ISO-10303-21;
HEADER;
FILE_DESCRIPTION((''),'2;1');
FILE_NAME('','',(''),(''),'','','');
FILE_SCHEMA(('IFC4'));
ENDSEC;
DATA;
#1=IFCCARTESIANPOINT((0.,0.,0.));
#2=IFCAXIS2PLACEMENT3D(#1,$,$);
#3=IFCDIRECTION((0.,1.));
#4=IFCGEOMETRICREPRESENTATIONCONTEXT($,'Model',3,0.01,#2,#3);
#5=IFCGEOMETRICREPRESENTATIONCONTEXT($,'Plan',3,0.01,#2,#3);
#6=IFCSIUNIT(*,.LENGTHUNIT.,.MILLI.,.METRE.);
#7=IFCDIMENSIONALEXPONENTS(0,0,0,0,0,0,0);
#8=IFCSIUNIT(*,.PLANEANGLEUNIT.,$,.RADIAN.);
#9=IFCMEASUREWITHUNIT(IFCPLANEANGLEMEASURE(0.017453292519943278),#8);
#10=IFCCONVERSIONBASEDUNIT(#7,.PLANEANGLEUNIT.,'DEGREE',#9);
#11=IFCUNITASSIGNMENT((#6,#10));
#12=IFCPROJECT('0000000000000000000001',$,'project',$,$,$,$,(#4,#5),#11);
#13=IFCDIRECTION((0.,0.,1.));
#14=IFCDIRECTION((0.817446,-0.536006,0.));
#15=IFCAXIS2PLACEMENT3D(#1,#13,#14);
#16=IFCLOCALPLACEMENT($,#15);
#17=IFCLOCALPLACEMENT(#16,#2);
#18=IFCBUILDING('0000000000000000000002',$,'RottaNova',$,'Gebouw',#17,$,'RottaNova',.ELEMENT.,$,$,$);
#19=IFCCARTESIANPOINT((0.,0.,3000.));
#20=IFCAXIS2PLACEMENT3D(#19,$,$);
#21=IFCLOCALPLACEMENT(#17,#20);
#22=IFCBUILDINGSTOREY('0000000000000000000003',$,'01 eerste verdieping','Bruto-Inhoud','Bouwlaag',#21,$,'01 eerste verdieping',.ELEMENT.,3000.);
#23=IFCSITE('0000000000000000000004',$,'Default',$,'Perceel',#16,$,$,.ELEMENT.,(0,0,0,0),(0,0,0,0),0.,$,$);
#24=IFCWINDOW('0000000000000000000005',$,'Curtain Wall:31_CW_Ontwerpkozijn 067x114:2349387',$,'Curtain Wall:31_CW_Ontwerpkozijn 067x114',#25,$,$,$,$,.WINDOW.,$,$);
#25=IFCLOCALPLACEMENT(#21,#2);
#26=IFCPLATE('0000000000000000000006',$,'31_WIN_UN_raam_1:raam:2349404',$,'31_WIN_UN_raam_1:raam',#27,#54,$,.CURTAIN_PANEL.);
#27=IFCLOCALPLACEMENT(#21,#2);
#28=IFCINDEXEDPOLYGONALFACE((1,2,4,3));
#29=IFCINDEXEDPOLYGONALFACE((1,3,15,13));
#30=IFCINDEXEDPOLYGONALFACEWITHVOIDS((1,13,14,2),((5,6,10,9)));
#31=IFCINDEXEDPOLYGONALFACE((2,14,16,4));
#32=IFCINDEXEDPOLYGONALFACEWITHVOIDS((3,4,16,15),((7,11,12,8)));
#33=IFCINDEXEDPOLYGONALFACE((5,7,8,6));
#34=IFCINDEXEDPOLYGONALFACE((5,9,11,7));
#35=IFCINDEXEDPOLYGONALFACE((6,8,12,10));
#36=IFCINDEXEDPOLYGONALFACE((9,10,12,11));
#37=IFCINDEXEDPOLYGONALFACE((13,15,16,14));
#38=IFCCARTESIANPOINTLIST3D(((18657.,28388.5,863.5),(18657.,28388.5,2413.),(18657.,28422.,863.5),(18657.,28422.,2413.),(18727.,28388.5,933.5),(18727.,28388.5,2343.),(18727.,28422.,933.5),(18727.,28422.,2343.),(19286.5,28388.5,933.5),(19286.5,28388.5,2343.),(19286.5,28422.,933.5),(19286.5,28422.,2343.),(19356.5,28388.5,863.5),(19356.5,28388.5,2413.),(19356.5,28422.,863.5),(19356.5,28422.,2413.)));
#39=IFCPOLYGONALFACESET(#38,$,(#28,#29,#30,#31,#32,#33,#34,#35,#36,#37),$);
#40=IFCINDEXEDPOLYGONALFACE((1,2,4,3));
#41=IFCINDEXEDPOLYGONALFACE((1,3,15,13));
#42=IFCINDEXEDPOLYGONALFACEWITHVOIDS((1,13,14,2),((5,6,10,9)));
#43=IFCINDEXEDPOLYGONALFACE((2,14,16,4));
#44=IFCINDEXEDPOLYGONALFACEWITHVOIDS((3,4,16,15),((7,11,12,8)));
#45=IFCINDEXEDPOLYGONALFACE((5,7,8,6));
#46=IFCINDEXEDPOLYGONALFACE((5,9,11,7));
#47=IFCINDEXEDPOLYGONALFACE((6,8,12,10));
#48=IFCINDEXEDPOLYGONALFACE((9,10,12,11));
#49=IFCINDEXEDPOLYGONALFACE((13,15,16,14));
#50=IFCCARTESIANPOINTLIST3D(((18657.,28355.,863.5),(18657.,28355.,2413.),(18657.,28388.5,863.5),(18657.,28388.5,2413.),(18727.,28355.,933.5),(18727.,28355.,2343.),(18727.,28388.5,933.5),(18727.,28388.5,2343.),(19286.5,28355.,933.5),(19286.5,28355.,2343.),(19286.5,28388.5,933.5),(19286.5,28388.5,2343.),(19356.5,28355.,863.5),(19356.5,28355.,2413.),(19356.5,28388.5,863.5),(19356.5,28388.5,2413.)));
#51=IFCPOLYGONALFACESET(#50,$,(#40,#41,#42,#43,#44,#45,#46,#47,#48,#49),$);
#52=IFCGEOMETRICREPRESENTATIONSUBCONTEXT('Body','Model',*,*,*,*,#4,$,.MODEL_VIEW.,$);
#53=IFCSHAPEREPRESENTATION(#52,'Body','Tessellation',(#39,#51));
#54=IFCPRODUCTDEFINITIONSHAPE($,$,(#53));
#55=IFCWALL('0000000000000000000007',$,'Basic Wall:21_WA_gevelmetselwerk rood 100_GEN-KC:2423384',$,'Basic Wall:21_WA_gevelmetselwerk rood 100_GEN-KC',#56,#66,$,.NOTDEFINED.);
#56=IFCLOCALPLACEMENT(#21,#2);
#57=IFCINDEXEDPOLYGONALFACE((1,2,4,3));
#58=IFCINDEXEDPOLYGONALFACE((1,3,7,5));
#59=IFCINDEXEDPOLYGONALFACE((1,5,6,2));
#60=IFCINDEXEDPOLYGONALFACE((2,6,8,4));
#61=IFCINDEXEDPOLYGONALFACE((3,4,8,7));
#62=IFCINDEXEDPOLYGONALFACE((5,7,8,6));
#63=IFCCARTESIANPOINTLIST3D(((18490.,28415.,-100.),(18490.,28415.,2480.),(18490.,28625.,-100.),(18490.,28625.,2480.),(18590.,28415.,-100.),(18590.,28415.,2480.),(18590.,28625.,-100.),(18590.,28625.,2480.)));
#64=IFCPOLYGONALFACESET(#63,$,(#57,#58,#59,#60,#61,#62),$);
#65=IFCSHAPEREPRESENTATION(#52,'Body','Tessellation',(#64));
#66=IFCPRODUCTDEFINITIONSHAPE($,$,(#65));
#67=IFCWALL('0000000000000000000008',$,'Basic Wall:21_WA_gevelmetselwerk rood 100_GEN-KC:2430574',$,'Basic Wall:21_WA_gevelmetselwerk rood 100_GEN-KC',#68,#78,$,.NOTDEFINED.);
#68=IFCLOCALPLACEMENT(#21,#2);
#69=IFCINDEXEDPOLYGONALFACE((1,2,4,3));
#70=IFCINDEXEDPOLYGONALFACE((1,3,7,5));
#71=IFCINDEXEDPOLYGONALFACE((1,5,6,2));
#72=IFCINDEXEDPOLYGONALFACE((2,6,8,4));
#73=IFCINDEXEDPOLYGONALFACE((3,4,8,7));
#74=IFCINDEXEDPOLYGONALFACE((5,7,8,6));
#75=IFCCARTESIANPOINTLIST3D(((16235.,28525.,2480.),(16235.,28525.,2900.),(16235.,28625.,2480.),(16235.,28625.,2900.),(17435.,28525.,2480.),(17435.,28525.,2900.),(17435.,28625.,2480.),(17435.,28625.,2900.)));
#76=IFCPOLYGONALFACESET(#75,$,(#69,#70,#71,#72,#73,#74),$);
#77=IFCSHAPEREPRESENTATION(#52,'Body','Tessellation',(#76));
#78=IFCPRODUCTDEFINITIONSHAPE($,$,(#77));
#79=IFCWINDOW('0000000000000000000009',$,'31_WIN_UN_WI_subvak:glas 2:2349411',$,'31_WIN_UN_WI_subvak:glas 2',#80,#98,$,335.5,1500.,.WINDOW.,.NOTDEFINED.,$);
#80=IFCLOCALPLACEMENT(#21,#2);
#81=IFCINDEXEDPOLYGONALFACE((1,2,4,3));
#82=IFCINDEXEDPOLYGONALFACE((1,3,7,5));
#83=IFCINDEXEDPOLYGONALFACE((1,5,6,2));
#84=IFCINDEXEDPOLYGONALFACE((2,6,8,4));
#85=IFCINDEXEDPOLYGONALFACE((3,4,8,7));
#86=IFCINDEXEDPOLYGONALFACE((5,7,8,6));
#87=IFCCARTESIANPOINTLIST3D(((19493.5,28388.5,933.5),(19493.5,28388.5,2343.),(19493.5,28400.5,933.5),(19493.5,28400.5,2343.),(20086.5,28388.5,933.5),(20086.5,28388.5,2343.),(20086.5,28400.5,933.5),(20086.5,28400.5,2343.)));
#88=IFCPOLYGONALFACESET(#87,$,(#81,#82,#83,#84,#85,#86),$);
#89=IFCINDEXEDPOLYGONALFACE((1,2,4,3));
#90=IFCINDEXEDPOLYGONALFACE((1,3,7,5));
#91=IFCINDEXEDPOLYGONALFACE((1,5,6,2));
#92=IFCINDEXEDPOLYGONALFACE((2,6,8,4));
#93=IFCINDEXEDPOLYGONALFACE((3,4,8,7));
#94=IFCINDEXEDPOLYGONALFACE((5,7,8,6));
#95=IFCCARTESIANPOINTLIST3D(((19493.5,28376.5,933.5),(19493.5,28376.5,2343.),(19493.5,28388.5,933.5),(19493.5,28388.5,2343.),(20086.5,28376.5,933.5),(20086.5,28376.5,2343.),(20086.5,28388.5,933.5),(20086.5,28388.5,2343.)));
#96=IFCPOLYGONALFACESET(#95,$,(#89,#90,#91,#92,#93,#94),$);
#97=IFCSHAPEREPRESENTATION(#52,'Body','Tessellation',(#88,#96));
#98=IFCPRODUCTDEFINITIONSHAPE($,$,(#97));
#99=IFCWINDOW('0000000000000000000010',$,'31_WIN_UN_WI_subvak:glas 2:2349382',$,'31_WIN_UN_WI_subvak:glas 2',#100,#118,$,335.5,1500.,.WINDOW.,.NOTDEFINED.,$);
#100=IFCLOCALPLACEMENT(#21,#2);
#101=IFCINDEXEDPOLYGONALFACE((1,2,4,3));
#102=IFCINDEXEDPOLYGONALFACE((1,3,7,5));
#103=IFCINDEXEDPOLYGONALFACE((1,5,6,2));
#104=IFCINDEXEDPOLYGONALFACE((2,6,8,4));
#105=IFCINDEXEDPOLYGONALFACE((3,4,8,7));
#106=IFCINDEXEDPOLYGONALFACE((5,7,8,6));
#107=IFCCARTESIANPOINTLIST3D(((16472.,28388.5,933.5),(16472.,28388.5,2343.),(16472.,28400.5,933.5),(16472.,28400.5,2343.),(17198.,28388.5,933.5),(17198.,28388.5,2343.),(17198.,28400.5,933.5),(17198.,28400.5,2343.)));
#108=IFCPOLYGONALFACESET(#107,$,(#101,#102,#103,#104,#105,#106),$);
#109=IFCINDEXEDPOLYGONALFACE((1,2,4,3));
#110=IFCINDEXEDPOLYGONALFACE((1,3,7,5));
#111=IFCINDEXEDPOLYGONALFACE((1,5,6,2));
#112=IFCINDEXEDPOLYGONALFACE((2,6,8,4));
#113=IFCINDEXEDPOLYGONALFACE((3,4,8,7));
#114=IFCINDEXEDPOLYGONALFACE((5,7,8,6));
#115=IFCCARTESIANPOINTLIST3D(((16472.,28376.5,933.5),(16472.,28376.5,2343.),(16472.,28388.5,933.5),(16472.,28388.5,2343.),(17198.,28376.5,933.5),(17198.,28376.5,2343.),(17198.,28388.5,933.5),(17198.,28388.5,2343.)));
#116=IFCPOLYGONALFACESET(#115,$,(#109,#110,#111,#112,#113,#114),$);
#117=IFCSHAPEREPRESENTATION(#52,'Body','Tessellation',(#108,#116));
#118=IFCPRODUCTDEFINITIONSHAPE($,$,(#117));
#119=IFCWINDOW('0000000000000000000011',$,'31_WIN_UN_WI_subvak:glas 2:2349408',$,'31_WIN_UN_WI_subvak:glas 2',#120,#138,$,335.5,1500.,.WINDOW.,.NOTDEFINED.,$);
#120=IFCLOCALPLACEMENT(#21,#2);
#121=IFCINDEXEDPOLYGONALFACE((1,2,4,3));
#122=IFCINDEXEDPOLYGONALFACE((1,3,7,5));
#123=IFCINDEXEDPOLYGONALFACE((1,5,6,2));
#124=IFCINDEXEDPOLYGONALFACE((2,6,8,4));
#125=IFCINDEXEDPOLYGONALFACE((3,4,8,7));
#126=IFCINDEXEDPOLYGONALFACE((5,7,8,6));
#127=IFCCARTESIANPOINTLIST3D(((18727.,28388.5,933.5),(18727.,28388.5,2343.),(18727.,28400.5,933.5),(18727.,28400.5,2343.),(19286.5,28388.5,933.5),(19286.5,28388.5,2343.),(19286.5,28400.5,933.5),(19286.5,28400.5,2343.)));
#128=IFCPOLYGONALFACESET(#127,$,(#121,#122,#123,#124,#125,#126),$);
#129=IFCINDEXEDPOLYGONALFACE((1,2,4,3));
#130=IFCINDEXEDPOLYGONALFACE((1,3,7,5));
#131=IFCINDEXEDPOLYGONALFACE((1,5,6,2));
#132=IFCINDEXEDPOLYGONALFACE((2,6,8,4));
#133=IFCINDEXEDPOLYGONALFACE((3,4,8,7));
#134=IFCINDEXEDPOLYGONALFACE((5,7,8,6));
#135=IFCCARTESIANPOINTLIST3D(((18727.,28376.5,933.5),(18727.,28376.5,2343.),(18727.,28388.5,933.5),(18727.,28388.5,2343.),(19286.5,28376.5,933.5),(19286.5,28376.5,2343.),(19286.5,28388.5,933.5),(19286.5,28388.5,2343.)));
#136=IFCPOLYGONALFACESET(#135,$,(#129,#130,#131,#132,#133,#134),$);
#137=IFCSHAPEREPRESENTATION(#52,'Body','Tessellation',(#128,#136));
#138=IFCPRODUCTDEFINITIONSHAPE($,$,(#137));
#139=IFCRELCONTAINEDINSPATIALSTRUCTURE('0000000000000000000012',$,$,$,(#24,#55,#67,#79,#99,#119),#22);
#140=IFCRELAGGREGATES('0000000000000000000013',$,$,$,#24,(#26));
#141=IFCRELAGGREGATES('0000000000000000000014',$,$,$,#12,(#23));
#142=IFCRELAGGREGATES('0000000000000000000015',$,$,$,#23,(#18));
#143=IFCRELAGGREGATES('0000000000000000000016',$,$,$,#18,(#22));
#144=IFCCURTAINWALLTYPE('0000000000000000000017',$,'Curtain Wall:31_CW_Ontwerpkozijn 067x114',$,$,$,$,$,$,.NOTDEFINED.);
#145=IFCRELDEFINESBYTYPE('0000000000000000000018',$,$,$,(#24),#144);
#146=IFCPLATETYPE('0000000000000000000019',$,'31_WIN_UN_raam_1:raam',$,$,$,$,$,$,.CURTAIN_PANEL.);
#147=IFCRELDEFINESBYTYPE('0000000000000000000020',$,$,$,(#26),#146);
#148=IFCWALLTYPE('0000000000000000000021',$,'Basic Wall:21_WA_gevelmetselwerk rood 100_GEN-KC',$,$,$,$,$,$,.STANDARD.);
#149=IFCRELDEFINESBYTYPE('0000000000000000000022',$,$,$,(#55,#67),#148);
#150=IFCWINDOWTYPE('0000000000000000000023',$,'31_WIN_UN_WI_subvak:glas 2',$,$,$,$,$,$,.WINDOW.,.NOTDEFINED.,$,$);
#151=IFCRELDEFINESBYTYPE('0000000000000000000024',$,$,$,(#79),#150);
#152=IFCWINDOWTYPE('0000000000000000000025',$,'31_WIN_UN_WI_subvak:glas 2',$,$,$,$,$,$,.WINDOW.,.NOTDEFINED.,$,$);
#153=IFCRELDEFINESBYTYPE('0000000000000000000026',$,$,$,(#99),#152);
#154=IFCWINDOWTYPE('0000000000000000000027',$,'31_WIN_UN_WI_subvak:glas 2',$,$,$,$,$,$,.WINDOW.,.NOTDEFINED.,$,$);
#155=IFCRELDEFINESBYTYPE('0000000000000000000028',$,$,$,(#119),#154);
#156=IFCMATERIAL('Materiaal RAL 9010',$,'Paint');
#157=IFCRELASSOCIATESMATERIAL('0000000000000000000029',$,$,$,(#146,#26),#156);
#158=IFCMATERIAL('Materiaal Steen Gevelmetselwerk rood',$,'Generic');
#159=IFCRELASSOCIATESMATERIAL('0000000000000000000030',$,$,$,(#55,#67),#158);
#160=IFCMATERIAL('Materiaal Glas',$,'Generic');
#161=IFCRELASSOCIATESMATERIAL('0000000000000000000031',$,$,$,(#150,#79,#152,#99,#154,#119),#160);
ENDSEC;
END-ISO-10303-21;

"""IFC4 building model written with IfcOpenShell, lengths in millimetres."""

from ifc_helpers import new_model, entity, si_unit, converted_unit, direction, frame, origin, place, context, subcontext, project, spatial, indexed_curve, outline, extrude, source, transform, mapped, material, type_object, type_shapes, element, aggregate, save


model = new_model("IFC4")

# Units and contexts
model_context = context("Model", 3, precision=0.01, world=origin(), true_north=direction((0.0, 1.0)))
plan_context = context("Plan", 3, precision=0.01, world=origin(), true_north=direction((0.0, 1.0)))
body_context = subcontext(model_context, "Body", "Model", "MODEL_VIEW")
ifc_project = project(units=[si_unit("LENGTHUNIT", "METRE", prefix="MILLI"), converted_unit("PLANEANGLEUNIT", "DEGREE", entity("IfcPlaneAngleMeasure", 0.017453292519943278), si_unit("PLANEANGLEUNIT", "RADIAN"), dimensions=[0, 0, 0, 0, 0, 0, 0])], contexts=[model_context, plan_context])

# Site, building, storey
site_placement = place(None, frame((0.0, 0.0, 0.0), z_axis=(0.0, 0.0, 1.0), x_axis=(0.817446, -0.536006, 0.0)))
site = spatial("IfcSite", under=ifc_project, at=site_placement, Name="Default", ObjectType="Perceel", CompositionType="ELEMENT", RefLatitude=(0, 0, 0, 0), RefLongitude=(0, 0, 0, 0), RefElevation=0.0)
building_placement = place(site_placement, origin())
building = spatial("IfcBuilding", under=site, at=building_placement, Name="RottaNova", ObjectType="Gebouw", LongName="RottaNova", CompositionType="ELEMENT")
storey_placement = place(building_placement, frame((0.0, 0.0, 3000.0)))
storey = spatial("IfcBuildingStorey", under=building, at=storey_placement, Name="01 eerste verdieping", Description="Bruto-Inhoud", ObjectType="Bouwlaag", LongName="01 eerste verdieping", CompositionType="ELEMENT", Elevation=3000.0)

# Window
curtain_wall_type = type_object("IfcCurtainWallType", Name="Curtain Wall:31_CW_Ontwerpkozijn 067x114", PredefinedType="NOTDEFINED")
window_1_placement = place(storey_placement, frame((0.0, 0.0, -3000.0)))
window_1 = element("IfcWindow", 1, at=window_1_placement, inside=storey, type_object=curtain_wall_type, Name="Curtain Wall:31_CW_Ontwerpkozijn 067x114:2349387", ObjectType="Curtain Wall:31_CW_Ontwerpkozijn 067x114", PredefinedType="WINDOW")

# Plate
ifc_material_1 = material(Name="Materiaal Glas", Category="Generic")
ifc_material_2 = material(Name="Materiaal RAL 9010", Category="Paint")
plate_type_1 = type_object("IfcPlateType", Name="31_WIN_UN_raam_1:raam", PredefinedType="CURTAIN_PANEL", material=ifc_material_2)
shared_shape_1 = source(origin(), body_context, "Body", "SweptSolid", [
    extrude(outline(indexed_curve([(-349.7, -774.8), (349.7, -774.8), (349.7, 774.8), (-349.7, 774.8), (-349.7, -774.8)], self_intersect=False), holes=[indexed_curve([(-279.7, 704.8), (279.7, 704.8), (279.7, -704.8), (-279.7, -704.8), (-279.7, 704.8)], self_intersect=False)]), frame((0.0, 58.5, 774.8), z_axis=(0.0, 1.0, 0.0), x_axis=(1.0, 0.0, 0.0)), (0.0, 0.0, 1.0), 33.5),
    extrude(outline(indexed_curve([(-349.7, -774.8), (349.7, -774.8), (349.7, 774.8), (-349.7, 774.8), (-349.7, -774.8)], self_intersect=False), holes=[indexed_curve([(-279.7, 704.7), (279.7, 704.7), (279.7, -704.8), (-279.7, -704.8), (-279.7, 704.7)], self_intersect=False)]), frame((0.0, 25.0, 774.8), z_axis=(0.0, 1.0, 0.0), x_axis=(1.0, 0.0, 0.0)), (0.0, 0.0, 1.0), 33.5),
])
type_shapes(plate_type_1, [shared_shape_1])
plate_1_placement = place(window_1_placement, frame((19006.8, 28330.0, 3863.5)))
plate_1 = element("IfcPlate", 2, at=plate_1_placement, type_object=plate_type_1, material=ifc_material_2, Name="31_WIN_UN_raam_1:raam:2349404", ObjectType="31_WIN_UN_raam_1:raam", PredefinedType="CURTAIN_PANEL", context=body_context, shape_type="MappedRepresentation", body=[
    mapped(shared_shape_1, transform((0.0, 0.0, 0.0), scale=1.0)),
])
aggregate(window_1, [plate_1])

# Walls
ifc_material_3 = material(Name="Materiaal Steen Gevelmetselwerk rood", Category="Generic")
wall_type = type_object("IfcWallType", Name="Basic Wall:21_WA_gevelmetselwerk rood 100_GEN-KC", PredefinedType="STANDARD")
wall_1_placement = place(storey_placement, frame((18540.0, 28415.0, -100.0), z_axis=(0.0, 0.0, 1.0), x_axis=(0.0, 1.0, 0.0)))
element("IfcWall", 3, at=wall_1_placement, inside=storey, type_object=wall_type, material=ifc_material_3, Name="Basic Wall:21_WA_gevelmetselwerk rood 100_GEN-KC:2423384", ObjectType="Basic Wall:21_WA_gevelmetselwerk rood 100_GEN-KC", PredefinedType="NOTDEFINED", context=body_context, shape_type="SweptSolid", body=[
    extrude(outline(indexed_curve([(210.0, 50.0), (0.0, 50.0), (0.0, -50.0), (210.0, -50.0), (210.0, 50.0)], self_intersect=False)), origin(), (0.0, 0.0, 1.0), 2580.0),
])
wall_2_placement = place(storey_placement, frame((17435.0, 28575.0, 2480.0), z_axis=(0.0, 0.0, 1.0), x_axis=(-1.0, 0.0, 0.0)))
element("IfcWall", 4, at=wall_2_placement, inside=storey, type_object=wall_type, material=ifc_material_3, Name="Basic Wall:21_WA_gevelmetselwerk rood 100_GEN-KC:2430574", ObjectType="Basic Wall:21_WA_gevelmetselwerk rood 100_GEN-KC", PredefinedType="NOTDEFINED", context=body_context, shape_type="SweptSolid", body=[
    extrude(outline(indexed_curve([(1200.0, 50.0), (0.0, 50.0), (0.0, -50.0), (1200.0, -50.0), (1200.0, 50.0)], self_intersect=False)), origin(), (0.0, 0.0, 1.0), 420.0),
])

# Windows
window_type_1 = type_object("IfcWindowType", Name="31_WIN_UN_WI_subvak:glas 2", PartitioningType="NOTDEFINED", PredefinedType="WINDOW", material=ifc_material_1)
shared_shape_2 = source(origin(), body_context, "Body", "SweptSolid", [
    extrude(outline(indexed_curve([(-6.0, -296.5), (6.0, -296.5), (6.0, 296.5), (-6.0, 296.5), (-6.0, -296.5)], self_intersect=False)), frame((0.0, 6.0, 0.0), z_axis=(0.0, 0.0, 1.0), x_axis=(0.0, -1.0, 0.0)), (0.0, 0.0, 1.0), 1409.5),
    extrude(outline(indexed_curve([(-6.0, -296.5), (6.0, -296.5), (6.0, 296.5), (-6.0, 296.5), (-6.0, -296.5)], self_intersect=False)), frame((0.0, -6.0, 0.0), z_axis=(0.0, 0.0, 1.0), x_axis=(0.0, -1.0, 0.0)), (0.0, 0.0, 1.0), 1409.5),
])
type_shapes(window_type_1, [shared_shape_2])
window_2_placement = place(storey_placement, frame((19790.0, 28388.5, 933.5)))
element("IfcWindow", 5, at=window_2_placement, inside=storey, type_object=window_type_1, material=ifc_material_1, Name="31_WIN_UN_WI_subvak:glas 2:2349411", ObjectType="31_WIN_UN_WI_subvak:glas 2", OverallHeight=335.5, OverallWidth=1500.0, PartitioningType="NOTDEFINED", PredefinedType="WINDOW", context=body_context, shape_type="MappedRepresentation", body=[
    mapped(shared_shape_2, transform((0.0, 0.0, 0.0), scale=1.0)),
])
window_type_2 = type_object("IfcWindowType", Name="31_WIN_UN_WI_subvak:glas 2", PartitioningType="NOTDEFINED", PredefinedType="WINDOW", material=ifc_material_1)
shared_shape_3 = source(origin(), body_context, "Body", "SweptSolid", [
    extrude(outline(indexed_curve([(-363.0, -6.0), (363.0, -6.0), (363.0, 6.0), (-363.0, 6.0), (-363.0, -6.0)], self_intersect=False)), frame((0.0, -6.0, 0.0)), (0.0, 0.0, 1.0), 1409.5),
    extrude(outline(indexed_curve([(-363.0, -6.0), (363.0, -6.0), (363.0, 6.0), (-363.0, 6.0), (-363.0, -6.0)], self_intersect=False)), frame((0.0, 6.0, 0.0)), (0.0, 0.0, 1.0), 1409.5),
])
type_shapes(window_type_2, [shared_shape_3])
window_3_placement = place(storey_placement, frame((16835.0, 28388.5, 933.5), z_axis=(0.0, 0.0, 1.0), x_axis=(-1.0, 0.0, 0.0)))
element("IfcWindow", 6, at=window_3_placement, inside=storey, type_object=window_type_2, material=ifc_material_1, Name="31_WIN_UN_WI_subvak:glas 2:2349382", ObjectType="31_WIN_UN_WI_subvak:glas 2", OverallHeight=335.5, OverallWidth=1500.0, PartitioningType="NOTDEFINED", PredefinedType="WINDOW", context=body_context, shape_type="MappedRepresentation", body=[
    mapped(shared_shape_3, transform((0.0, 0.0, 0.0), scale=1.0)),
])
window_type_3 = type_object("IfcWindowType", Name="31_WIN_UN_WI_subvak:glas 2", PartitioningType="NOTDEFINED", PredefinedType="WINDOW", material=ifc_material_1)
shared_shape_4 = source(origin(), body_context, "Body", "SweptSolid", [
    extrude(outline(indexed_curve([(-6.0, -279.8), (6.0, -279.8), (6.0, 279.8), (-6.0, 279.8), (-6.0, -279.8)], self_intersect=False)), frame((0.0, 6.0, 0.0), z_axis=(0.0, 0.0, 1.0), x_axis=(0.0, -1.0, 0.0)), (0.0, 0.0, 1.0), 1409.5),
    extrude(outline(indexed_curve([(-6.0, -279.8), (6.0, -279.8), (6.0, 279.8), (-6.0, 279.8), (-6.0, -279.8)], self_intersect=False)), frame((0.0, -6.0, 0.0), z_axis=(0.0, 0.0, 1.0), x_axis=(0.0, -1.0, 0.0)), (0.0, 0.0, 1.0), 1409.5),
])
type_shapes(window_type_3, [shared_shape_4])
window_4_placement = place(storey_placement, frame((19006.8, 28388.5, 933.5)))
element("IfcWindow", 7, at=window_4_placement, inside=storey, type_object=window_type_3, material=ifc_material_1, Name="31_WIN_UN_WI_subvak:glas 2:2349408", ObjectType="31_WIN_UN_WI_subvak:glas 2", OverallHeight=335.5, OverallWidth=1500.0, PartitioningType="NOTDEFINED", PredefinedType="WINDOW", context=body_context, shape_type="MappedRepresentation", body=[
    mapped(shared_shape_4, transform((0.0, 0.0, 0.0), scale=1.0)),
])

save(model, "model.ifc")
